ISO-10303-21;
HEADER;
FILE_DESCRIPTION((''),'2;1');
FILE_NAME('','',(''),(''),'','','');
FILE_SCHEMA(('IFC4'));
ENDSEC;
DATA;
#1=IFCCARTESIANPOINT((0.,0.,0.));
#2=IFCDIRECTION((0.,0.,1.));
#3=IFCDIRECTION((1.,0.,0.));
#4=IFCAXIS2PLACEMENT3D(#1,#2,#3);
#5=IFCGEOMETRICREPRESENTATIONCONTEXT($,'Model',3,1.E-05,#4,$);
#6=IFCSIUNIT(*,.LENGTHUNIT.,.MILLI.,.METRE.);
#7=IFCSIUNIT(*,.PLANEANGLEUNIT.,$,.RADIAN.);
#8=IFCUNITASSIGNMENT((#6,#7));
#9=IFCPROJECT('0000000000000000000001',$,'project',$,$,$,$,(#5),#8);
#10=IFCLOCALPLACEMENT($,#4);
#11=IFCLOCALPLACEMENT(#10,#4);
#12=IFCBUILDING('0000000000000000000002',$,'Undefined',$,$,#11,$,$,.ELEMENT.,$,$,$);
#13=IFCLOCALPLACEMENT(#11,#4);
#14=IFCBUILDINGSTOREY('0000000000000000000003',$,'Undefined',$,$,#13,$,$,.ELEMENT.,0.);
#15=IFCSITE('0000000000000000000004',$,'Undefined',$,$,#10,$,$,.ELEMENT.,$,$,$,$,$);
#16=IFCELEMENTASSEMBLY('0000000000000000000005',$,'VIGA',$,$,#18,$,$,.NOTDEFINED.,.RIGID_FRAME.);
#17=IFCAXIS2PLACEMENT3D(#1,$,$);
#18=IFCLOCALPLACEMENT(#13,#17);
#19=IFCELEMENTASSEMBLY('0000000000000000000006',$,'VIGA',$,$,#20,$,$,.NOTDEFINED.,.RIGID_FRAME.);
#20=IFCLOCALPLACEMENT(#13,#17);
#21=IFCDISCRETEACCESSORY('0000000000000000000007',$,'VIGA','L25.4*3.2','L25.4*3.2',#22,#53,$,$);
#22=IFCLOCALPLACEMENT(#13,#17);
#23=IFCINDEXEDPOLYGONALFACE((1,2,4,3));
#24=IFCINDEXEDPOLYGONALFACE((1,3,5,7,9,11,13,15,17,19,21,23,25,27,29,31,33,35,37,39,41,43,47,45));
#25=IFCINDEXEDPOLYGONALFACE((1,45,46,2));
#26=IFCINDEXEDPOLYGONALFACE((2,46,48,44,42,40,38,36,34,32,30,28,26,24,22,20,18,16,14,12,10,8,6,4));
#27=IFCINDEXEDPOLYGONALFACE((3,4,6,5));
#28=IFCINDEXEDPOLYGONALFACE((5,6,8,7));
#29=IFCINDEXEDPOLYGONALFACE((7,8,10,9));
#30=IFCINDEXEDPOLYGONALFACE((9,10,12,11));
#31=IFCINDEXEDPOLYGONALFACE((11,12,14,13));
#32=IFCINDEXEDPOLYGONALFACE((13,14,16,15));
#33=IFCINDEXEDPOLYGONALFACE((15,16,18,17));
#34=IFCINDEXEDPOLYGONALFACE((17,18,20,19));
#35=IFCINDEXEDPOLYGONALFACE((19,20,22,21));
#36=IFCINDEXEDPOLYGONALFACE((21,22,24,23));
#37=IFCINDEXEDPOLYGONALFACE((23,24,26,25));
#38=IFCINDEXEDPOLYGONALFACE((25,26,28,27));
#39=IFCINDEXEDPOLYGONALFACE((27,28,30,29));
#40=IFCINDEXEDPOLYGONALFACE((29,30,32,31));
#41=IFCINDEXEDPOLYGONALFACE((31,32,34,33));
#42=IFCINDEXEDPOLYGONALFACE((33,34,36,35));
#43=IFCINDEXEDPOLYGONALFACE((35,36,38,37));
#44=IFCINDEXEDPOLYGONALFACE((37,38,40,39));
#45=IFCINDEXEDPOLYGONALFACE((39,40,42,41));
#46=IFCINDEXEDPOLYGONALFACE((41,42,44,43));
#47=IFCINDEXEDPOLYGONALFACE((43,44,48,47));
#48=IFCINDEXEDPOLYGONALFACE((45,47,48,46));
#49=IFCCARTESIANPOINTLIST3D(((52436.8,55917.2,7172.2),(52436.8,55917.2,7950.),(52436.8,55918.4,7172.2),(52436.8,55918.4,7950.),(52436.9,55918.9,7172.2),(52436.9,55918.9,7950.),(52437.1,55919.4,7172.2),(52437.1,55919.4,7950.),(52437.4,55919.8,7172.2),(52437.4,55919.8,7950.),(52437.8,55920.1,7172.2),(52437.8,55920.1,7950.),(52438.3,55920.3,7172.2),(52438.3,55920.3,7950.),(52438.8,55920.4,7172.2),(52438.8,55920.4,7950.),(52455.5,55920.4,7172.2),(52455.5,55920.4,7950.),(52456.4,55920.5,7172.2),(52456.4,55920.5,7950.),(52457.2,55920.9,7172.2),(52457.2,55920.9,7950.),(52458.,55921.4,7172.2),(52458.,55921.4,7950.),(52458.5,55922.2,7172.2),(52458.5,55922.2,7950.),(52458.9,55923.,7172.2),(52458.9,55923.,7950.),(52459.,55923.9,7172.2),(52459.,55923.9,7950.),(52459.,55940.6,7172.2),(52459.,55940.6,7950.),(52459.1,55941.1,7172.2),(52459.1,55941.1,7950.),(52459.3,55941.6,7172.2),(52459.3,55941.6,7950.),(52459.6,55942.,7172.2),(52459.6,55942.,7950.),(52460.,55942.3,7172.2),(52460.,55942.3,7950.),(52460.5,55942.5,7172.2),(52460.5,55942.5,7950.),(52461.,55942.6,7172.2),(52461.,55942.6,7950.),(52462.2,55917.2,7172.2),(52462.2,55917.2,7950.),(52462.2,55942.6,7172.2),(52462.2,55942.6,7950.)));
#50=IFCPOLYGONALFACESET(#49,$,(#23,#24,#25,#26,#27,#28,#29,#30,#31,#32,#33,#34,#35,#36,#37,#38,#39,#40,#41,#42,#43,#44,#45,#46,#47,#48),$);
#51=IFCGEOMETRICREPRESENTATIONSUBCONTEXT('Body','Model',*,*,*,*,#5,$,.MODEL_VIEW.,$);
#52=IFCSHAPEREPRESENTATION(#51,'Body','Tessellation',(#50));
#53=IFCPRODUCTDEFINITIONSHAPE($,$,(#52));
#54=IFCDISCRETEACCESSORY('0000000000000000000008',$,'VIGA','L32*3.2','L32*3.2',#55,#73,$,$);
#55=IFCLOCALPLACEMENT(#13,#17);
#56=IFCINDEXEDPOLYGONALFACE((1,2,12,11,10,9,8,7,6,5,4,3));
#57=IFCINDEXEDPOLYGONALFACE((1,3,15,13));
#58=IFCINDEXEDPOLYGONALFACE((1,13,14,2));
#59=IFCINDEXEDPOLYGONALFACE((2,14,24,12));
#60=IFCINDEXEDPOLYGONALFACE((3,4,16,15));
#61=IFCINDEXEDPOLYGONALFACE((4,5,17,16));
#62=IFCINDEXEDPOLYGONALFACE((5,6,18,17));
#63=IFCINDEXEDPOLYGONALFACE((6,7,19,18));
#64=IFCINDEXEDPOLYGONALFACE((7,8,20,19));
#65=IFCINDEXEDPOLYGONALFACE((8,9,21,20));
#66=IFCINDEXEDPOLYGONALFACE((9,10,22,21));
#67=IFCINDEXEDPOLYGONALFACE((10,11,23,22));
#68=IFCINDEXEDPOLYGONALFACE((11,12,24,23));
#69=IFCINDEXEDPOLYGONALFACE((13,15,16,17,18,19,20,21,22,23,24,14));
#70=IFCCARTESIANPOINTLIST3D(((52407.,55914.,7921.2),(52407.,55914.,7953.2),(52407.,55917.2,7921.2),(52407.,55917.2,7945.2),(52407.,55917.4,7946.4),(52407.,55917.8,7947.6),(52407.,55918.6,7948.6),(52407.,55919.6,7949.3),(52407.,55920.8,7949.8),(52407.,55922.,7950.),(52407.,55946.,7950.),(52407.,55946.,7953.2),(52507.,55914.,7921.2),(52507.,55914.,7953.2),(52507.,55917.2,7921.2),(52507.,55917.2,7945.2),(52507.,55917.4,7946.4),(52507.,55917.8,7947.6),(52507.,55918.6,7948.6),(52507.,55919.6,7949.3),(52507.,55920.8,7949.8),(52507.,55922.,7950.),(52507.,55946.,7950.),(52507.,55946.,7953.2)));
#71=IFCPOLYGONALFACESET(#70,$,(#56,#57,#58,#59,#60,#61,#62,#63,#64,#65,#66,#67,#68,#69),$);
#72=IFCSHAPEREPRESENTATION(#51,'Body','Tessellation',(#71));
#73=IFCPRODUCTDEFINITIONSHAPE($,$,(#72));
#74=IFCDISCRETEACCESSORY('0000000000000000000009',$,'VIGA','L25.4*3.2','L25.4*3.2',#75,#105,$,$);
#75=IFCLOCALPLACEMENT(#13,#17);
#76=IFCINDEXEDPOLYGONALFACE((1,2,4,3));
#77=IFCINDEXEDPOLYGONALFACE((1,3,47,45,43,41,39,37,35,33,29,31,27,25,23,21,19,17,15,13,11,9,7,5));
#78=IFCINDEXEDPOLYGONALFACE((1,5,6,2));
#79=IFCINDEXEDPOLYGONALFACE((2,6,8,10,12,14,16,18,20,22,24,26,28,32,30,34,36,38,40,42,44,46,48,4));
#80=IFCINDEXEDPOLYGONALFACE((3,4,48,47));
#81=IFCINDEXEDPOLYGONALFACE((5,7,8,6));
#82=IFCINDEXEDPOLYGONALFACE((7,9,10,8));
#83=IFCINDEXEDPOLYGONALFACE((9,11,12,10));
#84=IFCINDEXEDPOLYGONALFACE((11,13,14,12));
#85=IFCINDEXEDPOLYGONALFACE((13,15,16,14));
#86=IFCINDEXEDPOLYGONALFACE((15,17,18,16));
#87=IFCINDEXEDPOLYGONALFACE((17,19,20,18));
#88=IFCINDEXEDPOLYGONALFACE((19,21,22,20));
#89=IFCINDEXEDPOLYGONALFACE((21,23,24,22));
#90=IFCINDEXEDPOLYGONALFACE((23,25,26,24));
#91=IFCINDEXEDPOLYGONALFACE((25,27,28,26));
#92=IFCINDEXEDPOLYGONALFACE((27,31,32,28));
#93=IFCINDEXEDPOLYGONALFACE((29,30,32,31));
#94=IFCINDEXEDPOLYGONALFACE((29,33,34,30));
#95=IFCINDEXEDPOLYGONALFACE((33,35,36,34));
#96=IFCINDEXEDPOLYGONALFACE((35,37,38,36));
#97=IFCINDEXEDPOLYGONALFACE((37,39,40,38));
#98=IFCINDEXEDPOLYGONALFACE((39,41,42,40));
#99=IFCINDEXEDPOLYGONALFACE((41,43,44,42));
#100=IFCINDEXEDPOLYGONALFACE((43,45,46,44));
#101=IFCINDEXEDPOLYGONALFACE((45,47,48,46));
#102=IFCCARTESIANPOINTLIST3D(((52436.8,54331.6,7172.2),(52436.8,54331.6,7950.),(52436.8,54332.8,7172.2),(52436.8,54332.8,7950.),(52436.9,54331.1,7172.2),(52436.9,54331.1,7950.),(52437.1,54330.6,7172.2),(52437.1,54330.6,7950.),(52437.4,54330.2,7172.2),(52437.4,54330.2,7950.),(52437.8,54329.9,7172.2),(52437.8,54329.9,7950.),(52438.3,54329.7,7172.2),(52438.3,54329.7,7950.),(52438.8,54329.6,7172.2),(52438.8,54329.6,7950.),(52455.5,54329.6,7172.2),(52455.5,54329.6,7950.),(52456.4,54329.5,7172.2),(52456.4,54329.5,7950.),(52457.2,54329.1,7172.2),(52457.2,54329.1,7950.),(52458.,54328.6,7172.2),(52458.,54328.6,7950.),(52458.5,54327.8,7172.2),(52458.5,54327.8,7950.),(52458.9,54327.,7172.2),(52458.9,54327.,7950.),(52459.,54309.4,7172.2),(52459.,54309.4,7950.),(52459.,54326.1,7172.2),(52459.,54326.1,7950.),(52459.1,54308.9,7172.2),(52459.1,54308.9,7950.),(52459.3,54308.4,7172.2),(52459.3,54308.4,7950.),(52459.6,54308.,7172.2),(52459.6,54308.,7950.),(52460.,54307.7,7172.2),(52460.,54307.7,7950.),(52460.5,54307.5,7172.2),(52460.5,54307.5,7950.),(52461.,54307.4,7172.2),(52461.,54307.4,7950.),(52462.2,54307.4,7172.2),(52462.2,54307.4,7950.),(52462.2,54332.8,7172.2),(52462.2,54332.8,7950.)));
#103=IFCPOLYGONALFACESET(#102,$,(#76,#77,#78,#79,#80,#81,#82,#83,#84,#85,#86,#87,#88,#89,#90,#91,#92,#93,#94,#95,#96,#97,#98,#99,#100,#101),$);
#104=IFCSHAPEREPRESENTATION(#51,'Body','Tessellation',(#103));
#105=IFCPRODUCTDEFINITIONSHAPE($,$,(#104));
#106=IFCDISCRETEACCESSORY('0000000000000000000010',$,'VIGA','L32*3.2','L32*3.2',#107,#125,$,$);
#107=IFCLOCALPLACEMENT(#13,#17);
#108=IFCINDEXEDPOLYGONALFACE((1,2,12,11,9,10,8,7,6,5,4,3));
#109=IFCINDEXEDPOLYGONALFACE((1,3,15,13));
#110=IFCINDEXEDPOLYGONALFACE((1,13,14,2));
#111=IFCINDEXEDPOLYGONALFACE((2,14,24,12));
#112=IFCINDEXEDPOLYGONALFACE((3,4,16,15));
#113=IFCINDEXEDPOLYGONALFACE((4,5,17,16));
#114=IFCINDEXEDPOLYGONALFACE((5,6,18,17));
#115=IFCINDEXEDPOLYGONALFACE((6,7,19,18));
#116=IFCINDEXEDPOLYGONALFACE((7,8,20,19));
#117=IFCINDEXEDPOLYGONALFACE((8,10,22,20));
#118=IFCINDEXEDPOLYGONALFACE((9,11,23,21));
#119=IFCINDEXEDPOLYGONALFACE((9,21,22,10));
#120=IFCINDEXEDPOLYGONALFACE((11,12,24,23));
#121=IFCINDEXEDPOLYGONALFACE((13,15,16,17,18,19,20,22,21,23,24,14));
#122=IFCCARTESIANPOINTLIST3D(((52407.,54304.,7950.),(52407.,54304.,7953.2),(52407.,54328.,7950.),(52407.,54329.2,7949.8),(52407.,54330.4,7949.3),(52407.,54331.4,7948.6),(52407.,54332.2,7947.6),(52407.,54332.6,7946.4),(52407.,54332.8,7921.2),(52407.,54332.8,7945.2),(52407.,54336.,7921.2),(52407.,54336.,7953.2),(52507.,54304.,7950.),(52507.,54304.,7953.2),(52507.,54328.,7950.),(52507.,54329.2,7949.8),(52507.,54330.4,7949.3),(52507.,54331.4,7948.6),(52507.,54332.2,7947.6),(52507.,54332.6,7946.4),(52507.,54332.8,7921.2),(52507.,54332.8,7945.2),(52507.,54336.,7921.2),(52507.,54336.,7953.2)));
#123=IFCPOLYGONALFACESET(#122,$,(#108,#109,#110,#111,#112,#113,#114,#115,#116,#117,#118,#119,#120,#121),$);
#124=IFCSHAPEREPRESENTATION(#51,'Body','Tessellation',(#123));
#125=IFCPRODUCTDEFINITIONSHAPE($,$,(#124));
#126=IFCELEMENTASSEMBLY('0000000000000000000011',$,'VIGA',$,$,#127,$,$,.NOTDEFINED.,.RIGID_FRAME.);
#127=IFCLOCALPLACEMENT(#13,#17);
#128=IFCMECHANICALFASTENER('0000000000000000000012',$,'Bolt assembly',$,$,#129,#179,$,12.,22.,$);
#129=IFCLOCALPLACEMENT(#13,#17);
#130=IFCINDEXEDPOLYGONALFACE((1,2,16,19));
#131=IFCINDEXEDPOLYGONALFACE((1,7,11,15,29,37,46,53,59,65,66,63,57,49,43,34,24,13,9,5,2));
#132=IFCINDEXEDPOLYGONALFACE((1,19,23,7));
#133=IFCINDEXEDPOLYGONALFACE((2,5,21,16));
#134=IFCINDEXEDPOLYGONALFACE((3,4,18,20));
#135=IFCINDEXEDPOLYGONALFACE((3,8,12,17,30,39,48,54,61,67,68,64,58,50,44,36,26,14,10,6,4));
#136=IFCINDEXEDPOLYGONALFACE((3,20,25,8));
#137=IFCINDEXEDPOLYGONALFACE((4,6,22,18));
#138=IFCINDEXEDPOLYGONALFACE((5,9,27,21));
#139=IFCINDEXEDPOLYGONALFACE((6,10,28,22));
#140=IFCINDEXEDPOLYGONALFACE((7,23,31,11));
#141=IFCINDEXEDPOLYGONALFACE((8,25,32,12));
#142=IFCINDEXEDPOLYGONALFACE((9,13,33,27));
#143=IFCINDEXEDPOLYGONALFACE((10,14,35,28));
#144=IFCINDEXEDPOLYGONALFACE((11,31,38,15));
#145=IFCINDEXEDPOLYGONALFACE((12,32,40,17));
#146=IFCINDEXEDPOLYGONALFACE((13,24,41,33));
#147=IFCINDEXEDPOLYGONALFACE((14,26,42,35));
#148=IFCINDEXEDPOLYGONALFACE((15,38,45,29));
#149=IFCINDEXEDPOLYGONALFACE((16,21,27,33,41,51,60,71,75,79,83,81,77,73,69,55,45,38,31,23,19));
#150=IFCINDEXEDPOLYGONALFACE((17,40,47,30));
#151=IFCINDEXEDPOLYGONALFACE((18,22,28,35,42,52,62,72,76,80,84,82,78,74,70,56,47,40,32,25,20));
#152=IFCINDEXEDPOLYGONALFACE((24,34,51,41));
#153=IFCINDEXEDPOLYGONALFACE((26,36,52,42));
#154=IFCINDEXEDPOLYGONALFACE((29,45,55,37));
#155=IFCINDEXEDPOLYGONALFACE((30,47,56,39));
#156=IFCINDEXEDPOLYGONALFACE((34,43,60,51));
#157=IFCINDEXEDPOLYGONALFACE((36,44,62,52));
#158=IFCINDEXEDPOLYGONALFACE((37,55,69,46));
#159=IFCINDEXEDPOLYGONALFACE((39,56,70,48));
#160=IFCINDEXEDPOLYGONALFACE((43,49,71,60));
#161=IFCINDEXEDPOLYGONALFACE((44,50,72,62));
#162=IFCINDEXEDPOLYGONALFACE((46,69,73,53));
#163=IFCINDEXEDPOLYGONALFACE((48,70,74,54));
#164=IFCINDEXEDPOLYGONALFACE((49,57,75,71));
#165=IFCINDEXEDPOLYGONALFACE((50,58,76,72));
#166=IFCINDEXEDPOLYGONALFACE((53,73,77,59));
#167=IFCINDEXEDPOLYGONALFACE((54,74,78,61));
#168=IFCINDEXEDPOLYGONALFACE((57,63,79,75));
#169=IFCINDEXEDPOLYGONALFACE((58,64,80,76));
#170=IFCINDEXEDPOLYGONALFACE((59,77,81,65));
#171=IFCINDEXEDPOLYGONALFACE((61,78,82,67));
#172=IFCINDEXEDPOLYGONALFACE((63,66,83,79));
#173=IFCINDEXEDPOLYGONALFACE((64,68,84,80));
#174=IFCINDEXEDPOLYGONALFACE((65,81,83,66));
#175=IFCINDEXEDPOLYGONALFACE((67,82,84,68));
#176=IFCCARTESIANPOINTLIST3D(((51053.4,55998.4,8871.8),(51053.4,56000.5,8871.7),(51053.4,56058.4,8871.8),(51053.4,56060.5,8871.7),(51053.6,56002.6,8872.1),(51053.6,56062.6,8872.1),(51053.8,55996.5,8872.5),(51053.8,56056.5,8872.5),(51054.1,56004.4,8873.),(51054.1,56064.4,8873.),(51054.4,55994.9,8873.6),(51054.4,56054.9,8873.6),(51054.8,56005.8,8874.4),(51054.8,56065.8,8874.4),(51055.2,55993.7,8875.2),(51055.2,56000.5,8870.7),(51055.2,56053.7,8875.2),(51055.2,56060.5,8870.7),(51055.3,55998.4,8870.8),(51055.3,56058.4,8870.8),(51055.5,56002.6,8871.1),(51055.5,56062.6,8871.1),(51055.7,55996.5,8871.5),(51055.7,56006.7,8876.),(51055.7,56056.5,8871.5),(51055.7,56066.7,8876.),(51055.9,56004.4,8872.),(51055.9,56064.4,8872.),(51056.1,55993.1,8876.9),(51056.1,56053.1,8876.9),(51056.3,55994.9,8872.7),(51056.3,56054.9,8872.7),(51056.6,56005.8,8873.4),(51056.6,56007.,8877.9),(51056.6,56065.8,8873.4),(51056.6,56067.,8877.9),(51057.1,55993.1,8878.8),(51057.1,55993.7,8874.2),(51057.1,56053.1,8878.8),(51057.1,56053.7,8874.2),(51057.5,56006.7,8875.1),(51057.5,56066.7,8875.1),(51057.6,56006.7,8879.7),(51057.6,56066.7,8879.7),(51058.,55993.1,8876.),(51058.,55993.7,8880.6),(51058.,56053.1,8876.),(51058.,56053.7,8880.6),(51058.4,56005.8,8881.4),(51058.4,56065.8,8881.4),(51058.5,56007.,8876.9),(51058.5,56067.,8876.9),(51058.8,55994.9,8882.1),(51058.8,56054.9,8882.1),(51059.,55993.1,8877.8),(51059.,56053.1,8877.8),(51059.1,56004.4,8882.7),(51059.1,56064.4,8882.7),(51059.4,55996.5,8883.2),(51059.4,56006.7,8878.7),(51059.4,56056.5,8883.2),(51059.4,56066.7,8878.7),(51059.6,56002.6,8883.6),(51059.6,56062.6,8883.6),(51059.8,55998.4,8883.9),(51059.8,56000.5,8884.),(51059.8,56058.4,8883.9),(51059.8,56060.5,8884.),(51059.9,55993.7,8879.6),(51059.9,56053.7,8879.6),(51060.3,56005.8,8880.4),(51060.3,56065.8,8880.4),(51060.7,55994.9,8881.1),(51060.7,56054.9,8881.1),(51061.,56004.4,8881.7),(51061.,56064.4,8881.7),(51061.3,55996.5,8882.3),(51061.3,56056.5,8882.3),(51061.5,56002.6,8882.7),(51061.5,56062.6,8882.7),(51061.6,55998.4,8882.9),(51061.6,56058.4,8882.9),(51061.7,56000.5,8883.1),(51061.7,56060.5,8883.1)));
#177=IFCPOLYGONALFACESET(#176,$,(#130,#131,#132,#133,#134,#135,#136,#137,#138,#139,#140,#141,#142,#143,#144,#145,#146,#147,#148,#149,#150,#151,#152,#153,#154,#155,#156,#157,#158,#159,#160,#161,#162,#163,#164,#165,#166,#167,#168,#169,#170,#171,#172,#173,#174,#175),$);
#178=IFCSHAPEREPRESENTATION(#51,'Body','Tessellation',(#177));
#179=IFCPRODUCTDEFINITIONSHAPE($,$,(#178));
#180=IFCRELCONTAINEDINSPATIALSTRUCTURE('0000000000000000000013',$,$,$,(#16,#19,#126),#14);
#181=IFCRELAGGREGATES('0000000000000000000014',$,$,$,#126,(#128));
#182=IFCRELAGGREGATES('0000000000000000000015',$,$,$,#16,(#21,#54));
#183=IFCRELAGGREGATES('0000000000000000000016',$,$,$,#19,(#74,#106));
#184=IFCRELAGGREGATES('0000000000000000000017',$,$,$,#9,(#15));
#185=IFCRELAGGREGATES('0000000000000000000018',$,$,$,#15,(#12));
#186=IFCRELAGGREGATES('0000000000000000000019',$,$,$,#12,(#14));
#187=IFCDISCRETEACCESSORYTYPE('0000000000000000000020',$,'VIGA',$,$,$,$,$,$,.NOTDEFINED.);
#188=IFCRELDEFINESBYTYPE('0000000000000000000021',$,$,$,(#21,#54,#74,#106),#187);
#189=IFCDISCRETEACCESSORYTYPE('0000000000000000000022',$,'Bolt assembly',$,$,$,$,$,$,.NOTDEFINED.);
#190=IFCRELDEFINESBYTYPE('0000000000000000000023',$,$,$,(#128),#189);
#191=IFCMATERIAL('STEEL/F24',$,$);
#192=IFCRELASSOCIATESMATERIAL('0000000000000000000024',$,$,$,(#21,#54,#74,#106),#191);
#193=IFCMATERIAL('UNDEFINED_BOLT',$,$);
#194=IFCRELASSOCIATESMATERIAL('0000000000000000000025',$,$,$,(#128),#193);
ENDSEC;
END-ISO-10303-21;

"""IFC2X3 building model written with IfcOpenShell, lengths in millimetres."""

from ifc_helpers import new_model, si_unit, frame, origin_with_axes, origin_2d_with_axis, place, context, subcontext, project, spatial, circle, l_section, extrude, source, transform, mapped, material, type_object, element, aggregate, save


model = new_model("IFC2X3")

# Units and contexts
model_context = context("Model", 3, precision=1e-05, world=origin_with_axes())
body_context = subcontext(model_context, "Body", "Model", "MODEL_VIEW")
ifc_project = project(units=[si_unit("LENGTHUNIT", "METRE", prefix="MILLI"), si_unit("PLANEANGLEUNIT", "RADIAN")], contexts=[model_context])

# Site, building, storey
site_placement = place(None, origin_with_axes())
site = spatial("IfcSite", under=ifc_project, at=site_placement, Name="Undefined", CompositionType="ELEMENT")
building_placement = place(site_placement, origin_with_axes())
building = spatial("IfcBuilding", under=site, at=building_placement, Name="Undefined", CompositionType="ELEMENT")
storey_placement = place(building_placement, origin_with_axes())
storey = spatial("IfcBuildingStorey", under=building, at=storey_placement, Name="Undefined", CompositionType="ELEMENT", Elevation=0.0)

# Shared definitions
ifc_material_1 = material(Name="STEEL/F24")

# Element assemblies
assembly_1_placement = place(storey_placement, origin_with_axes())
assembly_1 = element("IfcElementAssembly", 1, at=assembly_1_placement, inside=storey, Name="VIGA", AssemblyPlace="NOTDEFINED", PredefinedType="RIGID_FRAME")
assembly_2_placement = place(storey_placement, origin_with_axes())
assembly_2 = element("IfcElementAssembly", 2, at=assembly_2_placement, inside=storey, Name="VIGA", AssemblyPlace="NOTDEFINED", PredefinedType="RIGID_FRAME")

# Discrete accessories
discrete_accessory_type_1 = type_object("IfcDiscreteAccessoryType", Name="VIGA")
discrete_accessory_1_placement = place(assembly_1_placement, frame((52449.5, 55929.9, 7172.2), z_axis=(0.0, 1.0, 0.0), x_axis=(0.0, 0.0, 1.0)))
discrete_accessory_1 = element("IfcDiscreteAccessory", 3, at=discrete_accessory_1_placement, type_object=discrete_accessory_type_1, material=ifc_material_1, Name="VIGA", Description="L25.4*3.2", ObjectType="L25.4*3.2", context=body_context, shape_type="SweptSolid", body=[
    extrude(l_section(Depth=25.4, Width=25.4, Thickness=3.2, FilletRadius=3.5, EdgeRadius=2.0, at=origin_2d_with_axis()), frame((777.7, 0.0, 0.0), z_axis=(-1.0, 0.0, 0.0), x_axis=(0.0, -1.0, 0.0)), (0.0, 0.0, 1.0), 777.7),
])
discrete_accessory_2_placement = place(assembly_1_placement, frame((52507.0, 55930.0, 7937.2), z_axis=(0.0, 1.0, 0.0), x_axis=(-1.0, 0.0, 0.0)))
discrete_accessory_2 = element("IfcDiscreteAccessory", 4, at=discrete_accessory_2_placement, type_object=discrete_accessory_type_1, material=ifc_material_1, Name="VIGA", Description="L32*3.2", ObjectType="L32*3.2", context=body_context, shape_type="SweptSolid", body=[
    extrude(l_section(Depth=32.0, Width=32.0, Thickness=3.2, FilletRadius=4.8, at=origin_2d_with_axis()), frame((100.0, 0.0, 0.0), z_axis=(-1.0, 0.0, 0.0), x_axis=(0.0, -1.0, 0.0)), (0.0, 0.0, 1.0), 100.0),
])
discrete_accessory_3_placement = place(assembly_2_placement, frame((52449.5, 54320.1, 7950.0), z_axis=(0.0, -1.0, 0.0), x_axis=(0.0, 0.0, -1.0)))
discrete_accessory_3 = element("IfcDiscreteAccessory", 5, at=discrete_accessory_3_placement, type_object=discrete_accessory_type_1, material=ifc_material_1, Name="VIGA", Description="L25.4*3.2", ObjectType="L25.4*3.2", context=body_context, shape_type="SweptSolid", body=[
    extrude(l_section(Depth=25.4, Width=25.4, Thickness=3.2, FilletRadius=3.5, EdgeRadius=2.0, at=origin_2d_with_axis()), frame((777.7, 0.0, 0.0), z_axis=(-1.0, 0.0, 0.0), x_axis=(0.0, -1.0, 0.0)), (0.0, 0.0, 1.0), 777.7),
])
discrete_accessory_4_placement = place(assembly_2_placement, frame((52407.0, 54320.0, 7937.2), z_axis=(0.0, -1.0, 0.0), x_axis=(1.0, 0.0, 0.0)))
discrete_accessory_4 = element("IfcDiscreteAccessory", 6, at=discrete_accessory_4_placement, type_object=discrete_accessory_type_1, material=ifc_material_1, Name="VIGA", Description="L32*3.2", ObjectType="L32*3.2", context=body_context, shape_type="SweptSolid", body=[
    extrude(l_section(Depth=32.0, Width=32.0, Thickness=3.2, FilletRadius=4.8, at=origin_2d_with_axis()), frame((100.0, 0.0, 0.0), z_axis=(-1.0, 0.0, 0.0), x_axis=(0.0, -1.0, 0.0)), (0.0, 0.0, 1.0), 100.0),
])

# Element assembly, mechanical fastener
assembly_3_placement = place(storey_placement, origin_with_axes())
assembly_3 = element("IfcElementAssembly", 7, at=assembly_3_placement, inside=storey, Name="VIGA", AssemblyPlace="NOTDEFINED", PredefinedType="RIGID_FRAME")
ifc_material_2 = material(Name="UNDEFINED_BOLT")
discrete_accessory_type_2 = type_object("IfcDiscreteAccessoryType", Name="Bolt assembly")
shared_shape_1 = source(origin_with_axes(), body_context, "Body", "SweptSolid", [
    extrude(circle(Radius=7.0, at=origin_2d_with_axis()), frame((0.0, -1.0, 0.0), z_axis=(0.0, 1.0, 0.0), x_axis=(1.0, 0.0, 0.0)), (0.0, 0.0, 1.0), 2.1),
])
mechanical_fastener_1_placement = place(assembly_3_placement, frame((51057.5, 56000.0, 8877.4), z_axis=(-0.463605, 0.0, -0.886042), x_axis=(0.0, 1.0, 0.0)))
mechanical_fastener_1 = element("IfcMechanicalFastener", 8, at=mechanical_fastener_1_placement, type_object=discrete_accessory_type_2, material=ifc_material_2, Name="Bolt assembly", NominalDiameter=12.0, NominalLength=22.0, context=body_context, shape_type="MappedRepresentation", body=[
    mapped(shared_shape_1, transform((0.0, 0.0, 0.0))),
    mapped(shared_shape_1, transform((60.0, 0.0, 0.0))),
])
aggregate(assembly_3, [mechanical_fastener_1])

aggregate(assembly_1, [discrete_accessory_1, discrete_accessory_2])
aggregate(assembly_2, [discrete_accessory_3, discrete_accessory_4])

save(model, "model.ifc")
